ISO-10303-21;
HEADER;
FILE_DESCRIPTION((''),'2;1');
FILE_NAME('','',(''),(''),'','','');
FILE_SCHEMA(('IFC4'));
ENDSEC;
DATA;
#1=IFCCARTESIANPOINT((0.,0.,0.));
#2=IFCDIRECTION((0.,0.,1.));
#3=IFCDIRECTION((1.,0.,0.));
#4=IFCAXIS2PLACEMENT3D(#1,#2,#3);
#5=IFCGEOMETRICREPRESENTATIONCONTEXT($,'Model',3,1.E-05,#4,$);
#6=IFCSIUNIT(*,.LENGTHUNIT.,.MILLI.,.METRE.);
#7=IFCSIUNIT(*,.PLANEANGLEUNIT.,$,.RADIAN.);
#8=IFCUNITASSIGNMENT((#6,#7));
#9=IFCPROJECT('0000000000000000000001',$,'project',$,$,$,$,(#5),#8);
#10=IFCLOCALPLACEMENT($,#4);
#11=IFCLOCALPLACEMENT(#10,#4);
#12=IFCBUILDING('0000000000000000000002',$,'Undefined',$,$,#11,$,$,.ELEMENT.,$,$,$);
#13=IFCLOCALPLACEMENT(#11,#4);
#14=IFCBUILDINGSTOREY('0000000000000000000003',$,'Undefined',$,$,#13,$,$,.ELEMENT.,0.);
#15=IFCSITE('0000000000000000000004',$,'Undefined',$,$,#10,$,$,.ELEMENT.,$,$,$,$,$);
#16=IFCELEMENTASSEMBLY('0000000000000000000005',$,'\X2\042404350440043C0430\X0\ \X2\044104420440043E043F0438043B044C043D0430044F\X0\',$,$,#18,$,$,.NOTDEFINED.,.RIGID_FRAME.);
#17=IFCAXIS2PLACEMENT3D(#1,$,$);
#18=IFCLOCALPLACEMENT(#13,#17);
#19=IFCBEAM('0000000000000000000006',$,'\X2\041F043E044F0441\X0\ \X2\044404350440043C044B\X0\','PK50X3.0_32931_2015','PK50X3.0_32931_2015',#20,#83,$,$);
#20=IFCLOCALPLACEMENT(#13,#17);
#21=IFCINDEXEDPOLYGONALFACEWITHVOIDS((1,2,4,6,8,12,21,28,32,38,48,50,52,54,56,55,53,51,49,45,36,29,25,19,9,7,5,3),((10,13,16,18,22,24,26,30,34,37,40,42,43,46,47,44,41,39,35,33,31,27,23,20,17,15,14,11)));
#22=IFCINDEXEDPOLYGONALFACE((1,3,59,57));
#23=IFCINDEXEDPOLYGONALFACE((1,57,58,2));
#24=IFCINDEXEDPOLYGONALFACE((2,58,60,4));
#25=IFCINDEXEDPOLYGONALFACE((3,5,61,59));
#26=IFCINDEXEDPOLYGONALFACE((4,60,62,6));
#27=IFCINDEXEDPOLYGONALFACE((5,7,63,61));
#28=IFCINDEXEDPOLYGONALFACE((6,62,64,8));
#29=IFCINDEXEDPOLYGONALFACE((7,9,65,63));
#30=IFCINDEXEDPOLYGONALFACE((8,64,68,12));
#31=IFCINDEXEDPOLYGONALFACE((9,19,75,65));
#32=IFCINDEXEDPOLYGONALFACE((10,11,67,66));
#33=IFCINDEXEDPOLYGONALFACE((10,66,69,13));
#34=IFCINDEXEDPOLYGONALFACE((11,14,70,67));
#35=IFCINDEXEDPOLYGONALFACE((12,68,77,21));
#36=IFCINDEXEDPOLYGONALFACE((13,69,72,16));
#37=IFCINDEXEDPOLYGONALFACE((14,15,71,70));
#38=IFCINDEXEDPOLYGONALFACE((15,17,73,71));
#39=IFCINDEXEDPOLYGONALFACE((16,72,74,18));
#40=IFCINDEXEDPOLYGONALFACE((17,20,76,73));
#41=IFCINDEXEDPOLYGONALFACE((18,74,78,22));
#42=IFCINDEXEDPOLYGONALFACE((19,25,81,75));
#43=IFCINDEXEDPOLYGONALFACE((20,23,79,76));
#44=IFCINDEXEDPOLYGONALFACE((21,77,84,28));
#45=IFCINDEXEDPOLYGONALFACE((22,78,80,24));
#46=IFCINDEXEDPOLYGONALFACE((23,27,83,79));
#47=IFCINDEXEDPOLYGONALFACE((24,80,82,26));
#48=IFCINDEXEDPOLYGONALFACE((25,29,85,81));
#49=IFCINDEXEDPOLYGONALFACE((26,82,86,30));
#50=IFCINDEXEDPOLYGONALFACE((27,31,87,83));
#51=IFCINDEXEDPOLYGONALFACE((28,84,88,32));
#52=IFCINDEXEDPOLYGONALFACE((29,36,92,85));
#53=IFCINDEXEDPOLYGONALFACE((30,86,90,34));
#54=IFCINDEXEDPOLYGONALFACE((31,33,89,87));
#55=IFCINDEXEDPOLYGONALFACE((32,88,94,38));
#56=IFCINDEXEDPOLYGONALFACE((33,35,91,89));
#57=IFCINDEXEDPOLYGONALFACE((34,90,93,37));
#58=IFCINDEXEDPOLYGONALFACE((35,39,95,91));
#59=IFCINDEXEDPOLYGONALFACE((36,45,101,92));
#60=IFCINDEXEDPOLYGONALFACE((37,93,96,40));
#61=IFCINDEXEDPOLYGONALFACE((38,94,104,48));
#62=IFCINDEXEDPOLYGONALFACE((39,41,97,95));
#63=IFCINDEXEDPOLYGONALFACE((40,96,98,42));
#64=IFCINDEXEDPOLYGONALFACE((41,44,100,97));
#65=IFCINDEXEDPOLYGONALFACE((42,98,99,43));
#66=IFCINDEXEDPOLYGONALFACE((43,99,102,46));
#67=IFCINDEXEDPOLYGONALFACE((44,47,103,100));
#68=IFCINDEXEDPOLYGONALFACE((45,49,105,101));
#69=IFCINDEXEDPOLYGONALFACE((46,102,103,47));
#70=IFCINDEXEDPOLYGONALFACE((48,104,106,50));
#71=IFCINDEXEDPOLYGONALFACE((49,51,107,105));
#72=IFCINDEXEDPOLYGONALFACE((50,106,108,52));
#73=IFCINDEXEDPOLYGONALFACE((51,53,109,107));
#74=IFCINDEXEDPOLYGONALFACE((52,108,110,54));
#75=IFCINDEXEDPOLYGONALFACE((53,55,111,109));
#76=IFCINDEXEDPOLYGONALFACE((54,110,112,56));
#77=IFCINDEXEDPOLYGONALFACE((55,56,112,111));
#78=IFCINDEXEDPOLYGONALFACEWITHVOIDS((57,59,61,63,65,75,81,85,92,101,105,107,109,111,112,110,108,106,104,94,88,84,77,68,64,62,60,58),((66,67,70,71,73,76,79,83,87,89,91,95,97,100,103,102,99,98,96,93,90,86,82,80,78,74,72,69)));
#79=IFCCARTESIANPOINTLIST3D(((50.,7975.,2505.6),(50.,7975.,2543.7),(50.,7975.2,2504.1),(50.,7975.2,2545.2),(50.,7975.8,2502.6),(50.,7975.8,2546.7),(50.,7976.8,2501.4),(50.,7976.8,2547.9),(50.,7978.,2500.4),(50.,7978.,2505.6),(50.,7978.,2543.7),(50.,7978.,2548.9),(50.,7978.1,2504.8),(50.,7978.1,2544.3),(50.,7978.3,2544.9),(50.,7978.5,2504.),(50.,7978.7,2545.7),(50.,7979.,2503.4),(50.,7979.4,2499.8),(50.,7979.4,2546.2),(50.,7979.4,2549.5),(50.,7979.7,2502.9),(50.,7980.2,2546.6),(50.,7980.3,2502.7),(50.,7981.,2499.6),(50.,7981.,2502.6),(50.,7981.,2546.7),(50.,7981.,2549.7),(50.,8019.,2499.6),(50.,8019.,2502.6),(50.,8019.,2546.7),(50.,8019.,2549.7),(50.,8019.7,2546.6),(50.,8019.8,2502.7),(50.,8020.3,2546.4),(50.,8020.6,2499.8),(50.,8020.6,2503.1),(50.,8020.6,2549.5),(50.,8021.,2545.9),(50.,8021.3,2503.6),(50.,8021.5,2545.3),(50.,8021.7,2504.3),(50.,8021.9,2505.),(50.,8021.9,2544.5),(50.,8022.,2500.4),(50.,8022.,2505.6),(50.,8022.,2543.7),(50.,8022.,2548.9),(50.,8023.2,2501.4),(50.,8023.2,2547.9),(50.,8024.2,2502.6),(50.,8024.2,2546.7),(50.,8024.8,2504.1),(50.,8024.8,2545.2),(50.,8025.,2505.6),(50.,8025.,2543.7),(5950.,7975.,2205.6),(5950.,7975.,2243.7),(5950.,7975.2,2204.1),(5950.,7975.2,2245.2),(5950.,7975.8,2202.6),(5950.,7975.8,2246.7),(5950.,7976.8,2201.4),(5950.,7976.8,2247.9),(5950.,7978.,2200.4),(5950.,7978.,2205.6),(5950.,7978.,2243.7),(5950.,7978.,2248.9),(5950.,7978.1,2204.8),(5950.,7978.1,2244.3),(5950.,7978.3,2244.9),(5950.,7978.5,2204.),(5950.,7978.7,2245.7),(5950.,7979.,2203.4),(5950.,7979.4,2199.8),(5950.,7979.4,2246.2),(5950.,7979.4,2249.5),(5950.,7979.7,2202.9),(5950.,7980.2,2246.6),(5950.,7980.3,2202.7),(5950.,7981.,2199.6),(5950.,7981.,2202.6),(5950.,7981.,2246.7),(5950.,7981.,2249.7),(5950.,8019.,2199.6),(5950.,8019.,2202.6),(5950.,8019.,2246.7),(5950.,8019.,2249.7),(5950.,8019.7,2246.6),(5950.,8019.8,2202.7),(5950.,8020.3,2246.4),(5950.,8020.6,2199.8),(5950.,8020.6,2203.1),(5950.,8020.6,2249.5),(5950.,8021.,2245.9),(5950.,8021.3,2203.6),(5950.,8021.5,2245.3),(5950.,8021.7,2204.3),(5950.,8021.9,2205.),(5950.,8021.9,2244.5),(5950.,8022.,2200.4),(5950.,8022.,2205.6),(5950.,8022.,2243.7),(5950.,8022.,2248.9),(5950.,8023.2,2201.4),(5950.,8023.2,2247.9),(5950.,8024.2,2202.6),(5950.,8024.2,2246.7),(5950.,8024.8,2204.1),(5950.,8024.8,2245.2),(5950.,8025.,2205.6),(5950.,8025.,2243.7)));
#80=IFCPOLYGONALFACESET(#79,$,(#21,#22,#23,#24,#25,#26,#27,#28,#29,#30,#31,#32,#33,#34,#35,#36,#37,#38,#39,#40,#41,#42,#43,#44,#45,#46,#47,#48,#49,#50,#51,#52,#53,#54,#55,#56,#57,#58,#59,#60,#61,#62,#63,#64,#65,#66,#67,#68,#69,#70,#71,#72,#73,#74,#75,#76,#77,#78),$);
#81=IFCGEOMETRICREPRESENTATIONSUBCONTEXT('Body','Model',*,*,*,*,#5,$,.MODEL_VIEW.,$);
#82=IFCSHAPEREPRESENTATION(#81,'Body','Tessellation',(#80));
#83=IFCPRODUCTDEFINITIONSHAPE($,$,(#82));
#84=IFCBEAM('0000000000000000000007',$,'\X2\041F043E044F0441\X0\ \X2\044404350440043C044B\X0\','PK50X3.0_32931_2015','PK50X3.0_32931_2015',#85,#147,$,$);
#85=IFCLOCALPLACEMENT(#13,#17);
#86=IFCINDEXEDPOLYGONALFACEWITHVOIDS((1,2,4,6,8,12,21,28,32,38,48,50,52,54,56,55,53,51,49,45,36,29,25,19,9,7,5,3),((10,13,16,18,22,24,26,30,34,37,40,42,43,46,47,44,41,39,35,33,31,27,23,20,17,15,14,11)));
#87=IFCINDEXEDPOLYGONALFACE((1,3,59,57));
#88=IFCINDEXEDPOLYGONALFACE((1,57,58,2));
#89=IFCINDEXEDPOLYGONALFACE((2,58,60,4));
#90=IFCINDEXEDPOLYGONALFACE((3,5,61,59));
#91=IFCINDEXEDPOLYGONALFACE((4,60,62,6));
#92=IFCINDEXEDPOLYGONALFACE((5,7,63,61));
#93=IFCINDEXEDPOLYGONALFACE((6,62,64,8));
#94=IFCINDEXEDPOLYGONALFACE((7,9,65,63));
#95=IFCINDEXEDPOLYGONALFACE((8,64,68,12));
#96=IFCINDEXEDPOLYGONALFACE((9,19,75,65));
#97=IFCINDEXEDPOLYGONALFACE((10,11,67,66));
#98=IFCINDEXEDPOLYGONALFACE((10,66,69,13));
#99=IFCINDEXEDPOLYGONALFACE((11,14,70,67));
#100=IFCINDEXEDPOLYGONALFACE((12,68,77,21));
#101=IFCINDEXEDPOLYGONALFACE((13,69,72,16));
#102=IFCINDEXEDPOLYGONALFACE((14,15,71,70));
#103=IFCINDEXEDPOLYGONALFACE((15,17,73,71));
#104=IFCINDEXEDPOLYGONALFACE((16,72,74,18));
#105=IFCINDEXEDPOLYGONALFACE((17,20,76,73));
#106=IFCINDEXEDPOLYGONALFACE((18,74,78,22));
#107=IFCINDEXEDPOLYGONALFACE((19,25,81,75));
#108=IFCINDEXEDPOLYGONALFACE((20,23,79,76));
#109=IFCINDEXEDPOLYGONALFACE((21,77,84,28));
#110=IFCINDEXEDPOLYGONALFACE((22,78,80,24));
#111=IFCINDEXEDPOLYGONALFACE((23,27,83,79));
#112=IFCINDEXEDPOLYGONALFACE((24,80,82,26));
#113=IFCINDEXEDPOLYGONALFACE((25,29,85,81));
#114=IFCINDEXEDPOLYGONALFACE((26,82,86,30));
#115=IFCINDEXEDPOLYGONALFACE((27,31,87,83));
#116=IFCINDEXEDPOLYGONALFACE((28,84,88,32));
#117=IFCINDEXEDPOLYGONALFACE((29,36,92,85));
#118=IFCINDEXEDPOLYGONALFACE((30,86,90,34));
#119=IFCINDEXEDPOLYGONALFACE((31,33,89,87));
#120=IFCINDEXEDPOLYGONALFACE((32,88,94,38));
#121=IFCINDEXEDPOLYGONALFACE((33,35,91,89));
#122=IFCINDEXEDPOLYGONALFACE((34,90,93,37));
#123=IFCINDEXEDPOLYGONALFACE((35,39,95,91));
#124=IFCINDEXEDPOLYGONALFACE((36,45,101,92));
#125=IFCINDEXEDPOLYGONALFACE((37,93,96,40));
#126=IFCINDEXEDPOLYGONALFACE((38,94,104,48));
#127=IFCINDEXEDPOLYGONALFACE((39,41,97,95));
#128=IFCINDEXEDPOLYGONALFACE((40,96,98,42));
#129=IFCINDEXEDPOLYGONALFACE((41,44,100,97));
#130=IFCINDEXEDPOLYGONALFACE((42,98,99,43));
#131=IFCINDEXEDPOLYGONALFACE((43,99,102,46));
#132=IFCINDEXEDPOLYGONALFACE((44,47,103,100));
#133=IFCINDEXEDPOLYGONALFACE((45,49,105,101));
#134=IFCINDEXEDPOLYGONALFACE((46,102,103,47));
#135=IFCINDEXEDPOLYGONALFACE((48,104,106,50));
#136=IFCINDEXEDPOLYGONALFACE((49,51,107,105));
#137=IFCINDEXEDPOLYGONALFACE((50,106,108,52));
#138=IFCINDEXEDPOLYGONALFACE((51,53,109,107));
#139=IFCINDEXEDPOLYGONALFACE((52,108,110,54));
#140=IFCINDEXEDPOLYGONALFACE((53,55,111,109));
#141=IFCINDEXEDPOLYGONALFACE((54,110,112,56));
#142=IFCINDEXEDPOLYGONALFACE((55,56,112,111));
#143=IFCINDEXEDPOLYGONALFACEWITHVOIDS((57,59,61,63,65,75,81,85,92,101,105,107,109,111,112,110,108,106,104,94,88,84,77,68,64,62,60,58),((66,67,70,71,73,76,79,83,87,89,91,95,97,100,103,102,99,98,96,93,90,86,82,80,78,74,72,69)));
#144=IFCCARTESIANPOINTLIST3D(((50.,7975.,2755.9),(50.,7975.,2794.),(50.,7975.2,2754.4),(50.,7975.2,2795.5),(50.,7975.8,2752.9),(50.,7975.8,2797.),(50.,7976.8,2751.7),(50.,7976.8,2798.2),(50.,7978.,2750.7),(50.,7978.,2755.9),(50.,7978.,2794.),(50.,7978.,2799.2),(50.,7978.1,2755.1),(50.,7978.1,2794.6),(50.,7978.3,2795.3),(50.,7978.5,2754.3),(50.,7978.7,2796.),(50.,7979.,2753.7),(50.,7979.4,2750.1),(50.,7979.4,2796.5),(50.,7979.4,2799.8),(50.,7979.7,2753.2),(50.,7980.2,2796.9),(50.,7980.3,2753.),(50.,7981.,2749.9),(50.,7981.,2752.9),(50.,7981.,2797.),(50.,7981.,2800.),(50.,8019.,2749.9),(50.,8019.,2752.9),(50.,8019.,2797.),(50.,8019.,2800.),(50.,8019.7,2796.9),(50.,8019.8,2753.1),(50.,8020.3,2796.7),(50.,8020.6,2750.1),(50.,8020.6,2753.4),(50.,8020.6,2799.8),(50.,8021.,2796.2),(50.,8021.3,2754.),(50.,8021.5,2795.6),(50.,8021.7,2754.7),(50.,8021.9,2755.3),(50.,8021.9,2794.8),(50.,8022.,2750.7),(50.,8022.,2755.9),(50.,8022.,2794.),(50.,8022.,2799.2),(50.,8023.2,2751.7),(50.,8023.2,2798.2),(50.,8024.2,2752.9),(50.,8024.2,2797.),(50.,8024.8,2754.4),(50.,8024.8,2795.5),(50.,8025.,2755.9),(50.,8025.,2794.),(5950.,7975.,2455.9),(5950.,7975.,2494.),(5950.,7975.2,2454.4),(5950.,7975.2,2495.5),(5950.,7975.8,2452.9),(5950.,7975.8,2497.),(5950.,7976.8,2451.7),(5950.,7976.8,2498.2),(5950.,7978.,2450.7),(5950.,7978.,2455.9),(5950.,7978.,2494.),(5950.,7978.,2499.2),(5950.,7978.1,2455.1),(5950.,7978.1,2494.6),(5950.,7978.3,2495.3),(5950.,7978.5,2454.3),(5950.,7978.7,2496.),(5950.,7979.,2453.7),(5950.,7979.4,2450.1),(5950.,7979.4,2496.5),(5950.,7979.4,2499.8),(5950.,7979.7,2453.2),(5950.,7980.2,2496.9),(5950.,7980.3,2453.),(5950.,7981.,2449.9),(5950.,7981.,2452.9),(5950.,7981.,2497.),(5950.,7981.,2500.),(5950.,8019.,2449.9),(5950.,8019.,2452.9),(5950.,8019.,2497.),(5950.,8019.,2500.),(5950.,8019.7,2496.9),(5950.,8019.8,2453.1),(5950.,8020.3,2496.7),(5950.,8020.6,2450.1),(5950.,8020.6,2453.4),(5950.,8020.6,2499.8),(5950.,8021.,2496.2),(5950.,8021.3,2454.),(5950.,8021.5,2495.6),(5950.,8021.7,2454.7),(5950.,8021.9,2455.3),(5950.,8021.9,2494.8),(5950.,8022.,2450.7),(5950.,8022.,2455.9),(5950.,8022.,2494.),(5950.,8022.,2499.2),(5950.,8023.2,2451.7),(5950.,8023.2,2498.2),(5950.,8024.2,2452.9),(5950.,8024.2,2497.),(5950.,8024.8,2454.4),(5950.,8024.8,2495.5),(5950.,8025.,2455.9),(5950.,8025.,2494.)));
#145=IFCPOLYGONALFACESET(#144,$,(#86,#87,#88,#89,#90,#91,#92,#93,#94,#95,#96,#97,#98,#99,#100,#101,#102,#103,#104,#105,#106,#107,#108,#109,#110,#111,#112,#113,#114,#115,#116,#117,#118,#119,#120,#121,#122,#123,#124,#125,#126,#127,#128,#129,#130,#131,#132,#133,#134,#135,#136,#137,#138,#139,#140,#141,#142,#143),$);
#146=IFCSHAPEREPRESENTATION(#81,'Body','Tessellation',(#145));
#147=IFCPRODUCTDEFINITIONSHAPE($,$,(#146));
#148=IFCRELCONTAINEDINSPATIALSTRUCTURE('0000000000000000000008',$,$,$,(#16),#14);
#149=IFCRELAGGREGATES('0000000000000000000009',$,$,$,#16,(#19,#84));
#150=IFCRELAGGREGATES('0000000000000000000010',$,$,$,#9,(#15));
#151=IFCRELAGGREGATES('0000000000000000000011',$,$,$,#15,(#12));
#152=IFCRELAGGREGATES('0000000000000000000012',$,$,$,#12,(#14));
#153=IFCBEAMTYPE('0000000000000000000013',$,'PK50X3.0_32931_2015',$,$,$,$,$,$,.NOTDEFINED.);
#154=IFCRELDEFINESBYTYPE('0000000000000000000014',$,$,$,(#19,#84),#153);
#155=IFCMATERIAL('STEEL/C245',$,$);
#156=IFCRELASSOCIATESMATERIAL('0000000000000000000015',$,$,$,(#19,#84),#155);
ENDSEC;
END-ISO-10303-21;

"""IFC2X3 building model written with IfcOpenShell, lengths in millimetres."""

from ifc_helpers import new_model, si_unit, frame, origin_with_axes, origin_2d_with_axis, place, context, subcontext, project, spatial, hollow_rectangle, extrude, clip, halfspace, material, type_object, element, aggregate, save


model = new_model("IFC2X3")

# Units and contexts
model_context = context("Model", 3, precision=1e-05, world=origin_with_axes())
body_context = subcontext(model_context, "Body", "Model", "MODEL_VIEW")
ifc_project = project(units=[si_unit("LENGTHUNIT", "METRE", prefix="MILLI"), si_unit("PLANEANGLEUNIT", "RADIAN")], contexts=[model_context])

# Site, building, storey
site_placement = place(None, origin_with_axes())
site = spatial("IfcSite", under=ifc_project, at=site_placement, Name="Undefined", CompositionType="ELEMENT")
building_placement = place(site_placement, origin_with_axes())
building = spatial("IfcBuilding", under=site, at=building_placement, Name="Undefined", CompositionType="ELEMENT")
storey_placement = place(building_placement, origin_with_axes())
storey = spatial("IfcBuildingStorey", under=building, at=storey_placement, Name="Undefined", CompositionType="ELEMENT", Elevation=0.0)

# Shared definitions
ifc_material_1 = material(Name="STEEL/C245")

# Element assembly
assembly_1_placement = place(storey_placement, origin_with_axes())
assembly_1 = element("IfcElementAssembly", 1, at=assembly_1_placement, inside=storey, Name="Ферма стропильная", AssemblyPlace="NOTDEFINED", PredefinedType="RIGID_FRAME")

# Beams
beam_type_1 = type_object("IfcBeamType", Name="PK50X3.0_32931_2015", PredefinedType="NOTDEFINED")
beam_1_placement = place(assembly_1_placement, frame((36.0, 8000.0, 2525.4), z_axis=(0.050782, 0.0, 0.99871), x_axis=(0.99871, 0.0, -0.050782)))
beam_1 = element("IfcBeam", 2, at=beam_1_placement, type_object=beam_type_1, material=ifc_material_1, Name="Пояс фермы", Description="PK50X3.0_32931_2015", ObjectType="PK50X3.0_32931_2015", context=body_context, shape_type="Clipping", body=[
    clip(clip(extrude(hollow_rectangle(XDim=50.0, YDim=50.0, WallThickness=3.0, InnerFilletRadius=3.0, OuterFilletRadius=6.0, at=origin_2d_with_axis()), frame((5924.2, 0.0, 0.0), z_axis=(-1.0, 0.0, 0.0), x_axis=(0.0, -1.0, 0.0)), (0.0, 0.0, 1.0), 5912.8), halfspace(frame((5907.6, 0.0, 275.0), z_axis=(0.99871, 0.0, 0.050782), x_axis=(0.0, -1.0, 0.0)), False)), halfspace(frame((0.0, 0.0, 275.0), z_axis=(0.99871, 0.0, 0.050782), x_axis=(0.0, -1.0, 0.0)), True)),
])
beam_2_placement = place(assembly_1_placement, frame((48.7, 8000.0, 2775.0), z_axis=(0.050782, 0.0, 0.99871), x_axis=(0.99871, 0.0, -0.050782)))
beam_2 = element("IfcBeam", 3, at=beam_2_placement, type_object=beam_type_1, material=ifc_material_1, Name="Пояс фермы", Description="PK50X3.0_32931_2015", ObjectType="PK50X3.0_32931_2015", context=body_context, shape_type="Clipping", body=[
    clip(clip(extrude(hollow_rectangle(XDim=50.0, YDim=50.0, WallThickness=3.0, InnerFilletRadius=3.0, OuterFilletRadius=6.0, at=origin_2d_with_axis()), frame((5911.5, 0.0, 0.0), z_axis=(-1.0, 0.0, 0.0), x_axis=(0.0, -1.0, 0.0)), (0.0, 0.0, 1.0), 5912.8), halfspace(frame((5907.6, 0.0, 25.0), z_axis=(0.99871, 0.0, 0.050782), x_axis=(0.0, -1.0, 0.0)), False)), halfspace(frame((0.0, 0.0, 25.0), z_axis=(0.99871, 0.0, 0.050782), x_axis=(0.0, -1.0, 0.0)), True)),
])
aggregate(assembly_1, [beam_1, beam_2])

save(model, "model.ifc")
